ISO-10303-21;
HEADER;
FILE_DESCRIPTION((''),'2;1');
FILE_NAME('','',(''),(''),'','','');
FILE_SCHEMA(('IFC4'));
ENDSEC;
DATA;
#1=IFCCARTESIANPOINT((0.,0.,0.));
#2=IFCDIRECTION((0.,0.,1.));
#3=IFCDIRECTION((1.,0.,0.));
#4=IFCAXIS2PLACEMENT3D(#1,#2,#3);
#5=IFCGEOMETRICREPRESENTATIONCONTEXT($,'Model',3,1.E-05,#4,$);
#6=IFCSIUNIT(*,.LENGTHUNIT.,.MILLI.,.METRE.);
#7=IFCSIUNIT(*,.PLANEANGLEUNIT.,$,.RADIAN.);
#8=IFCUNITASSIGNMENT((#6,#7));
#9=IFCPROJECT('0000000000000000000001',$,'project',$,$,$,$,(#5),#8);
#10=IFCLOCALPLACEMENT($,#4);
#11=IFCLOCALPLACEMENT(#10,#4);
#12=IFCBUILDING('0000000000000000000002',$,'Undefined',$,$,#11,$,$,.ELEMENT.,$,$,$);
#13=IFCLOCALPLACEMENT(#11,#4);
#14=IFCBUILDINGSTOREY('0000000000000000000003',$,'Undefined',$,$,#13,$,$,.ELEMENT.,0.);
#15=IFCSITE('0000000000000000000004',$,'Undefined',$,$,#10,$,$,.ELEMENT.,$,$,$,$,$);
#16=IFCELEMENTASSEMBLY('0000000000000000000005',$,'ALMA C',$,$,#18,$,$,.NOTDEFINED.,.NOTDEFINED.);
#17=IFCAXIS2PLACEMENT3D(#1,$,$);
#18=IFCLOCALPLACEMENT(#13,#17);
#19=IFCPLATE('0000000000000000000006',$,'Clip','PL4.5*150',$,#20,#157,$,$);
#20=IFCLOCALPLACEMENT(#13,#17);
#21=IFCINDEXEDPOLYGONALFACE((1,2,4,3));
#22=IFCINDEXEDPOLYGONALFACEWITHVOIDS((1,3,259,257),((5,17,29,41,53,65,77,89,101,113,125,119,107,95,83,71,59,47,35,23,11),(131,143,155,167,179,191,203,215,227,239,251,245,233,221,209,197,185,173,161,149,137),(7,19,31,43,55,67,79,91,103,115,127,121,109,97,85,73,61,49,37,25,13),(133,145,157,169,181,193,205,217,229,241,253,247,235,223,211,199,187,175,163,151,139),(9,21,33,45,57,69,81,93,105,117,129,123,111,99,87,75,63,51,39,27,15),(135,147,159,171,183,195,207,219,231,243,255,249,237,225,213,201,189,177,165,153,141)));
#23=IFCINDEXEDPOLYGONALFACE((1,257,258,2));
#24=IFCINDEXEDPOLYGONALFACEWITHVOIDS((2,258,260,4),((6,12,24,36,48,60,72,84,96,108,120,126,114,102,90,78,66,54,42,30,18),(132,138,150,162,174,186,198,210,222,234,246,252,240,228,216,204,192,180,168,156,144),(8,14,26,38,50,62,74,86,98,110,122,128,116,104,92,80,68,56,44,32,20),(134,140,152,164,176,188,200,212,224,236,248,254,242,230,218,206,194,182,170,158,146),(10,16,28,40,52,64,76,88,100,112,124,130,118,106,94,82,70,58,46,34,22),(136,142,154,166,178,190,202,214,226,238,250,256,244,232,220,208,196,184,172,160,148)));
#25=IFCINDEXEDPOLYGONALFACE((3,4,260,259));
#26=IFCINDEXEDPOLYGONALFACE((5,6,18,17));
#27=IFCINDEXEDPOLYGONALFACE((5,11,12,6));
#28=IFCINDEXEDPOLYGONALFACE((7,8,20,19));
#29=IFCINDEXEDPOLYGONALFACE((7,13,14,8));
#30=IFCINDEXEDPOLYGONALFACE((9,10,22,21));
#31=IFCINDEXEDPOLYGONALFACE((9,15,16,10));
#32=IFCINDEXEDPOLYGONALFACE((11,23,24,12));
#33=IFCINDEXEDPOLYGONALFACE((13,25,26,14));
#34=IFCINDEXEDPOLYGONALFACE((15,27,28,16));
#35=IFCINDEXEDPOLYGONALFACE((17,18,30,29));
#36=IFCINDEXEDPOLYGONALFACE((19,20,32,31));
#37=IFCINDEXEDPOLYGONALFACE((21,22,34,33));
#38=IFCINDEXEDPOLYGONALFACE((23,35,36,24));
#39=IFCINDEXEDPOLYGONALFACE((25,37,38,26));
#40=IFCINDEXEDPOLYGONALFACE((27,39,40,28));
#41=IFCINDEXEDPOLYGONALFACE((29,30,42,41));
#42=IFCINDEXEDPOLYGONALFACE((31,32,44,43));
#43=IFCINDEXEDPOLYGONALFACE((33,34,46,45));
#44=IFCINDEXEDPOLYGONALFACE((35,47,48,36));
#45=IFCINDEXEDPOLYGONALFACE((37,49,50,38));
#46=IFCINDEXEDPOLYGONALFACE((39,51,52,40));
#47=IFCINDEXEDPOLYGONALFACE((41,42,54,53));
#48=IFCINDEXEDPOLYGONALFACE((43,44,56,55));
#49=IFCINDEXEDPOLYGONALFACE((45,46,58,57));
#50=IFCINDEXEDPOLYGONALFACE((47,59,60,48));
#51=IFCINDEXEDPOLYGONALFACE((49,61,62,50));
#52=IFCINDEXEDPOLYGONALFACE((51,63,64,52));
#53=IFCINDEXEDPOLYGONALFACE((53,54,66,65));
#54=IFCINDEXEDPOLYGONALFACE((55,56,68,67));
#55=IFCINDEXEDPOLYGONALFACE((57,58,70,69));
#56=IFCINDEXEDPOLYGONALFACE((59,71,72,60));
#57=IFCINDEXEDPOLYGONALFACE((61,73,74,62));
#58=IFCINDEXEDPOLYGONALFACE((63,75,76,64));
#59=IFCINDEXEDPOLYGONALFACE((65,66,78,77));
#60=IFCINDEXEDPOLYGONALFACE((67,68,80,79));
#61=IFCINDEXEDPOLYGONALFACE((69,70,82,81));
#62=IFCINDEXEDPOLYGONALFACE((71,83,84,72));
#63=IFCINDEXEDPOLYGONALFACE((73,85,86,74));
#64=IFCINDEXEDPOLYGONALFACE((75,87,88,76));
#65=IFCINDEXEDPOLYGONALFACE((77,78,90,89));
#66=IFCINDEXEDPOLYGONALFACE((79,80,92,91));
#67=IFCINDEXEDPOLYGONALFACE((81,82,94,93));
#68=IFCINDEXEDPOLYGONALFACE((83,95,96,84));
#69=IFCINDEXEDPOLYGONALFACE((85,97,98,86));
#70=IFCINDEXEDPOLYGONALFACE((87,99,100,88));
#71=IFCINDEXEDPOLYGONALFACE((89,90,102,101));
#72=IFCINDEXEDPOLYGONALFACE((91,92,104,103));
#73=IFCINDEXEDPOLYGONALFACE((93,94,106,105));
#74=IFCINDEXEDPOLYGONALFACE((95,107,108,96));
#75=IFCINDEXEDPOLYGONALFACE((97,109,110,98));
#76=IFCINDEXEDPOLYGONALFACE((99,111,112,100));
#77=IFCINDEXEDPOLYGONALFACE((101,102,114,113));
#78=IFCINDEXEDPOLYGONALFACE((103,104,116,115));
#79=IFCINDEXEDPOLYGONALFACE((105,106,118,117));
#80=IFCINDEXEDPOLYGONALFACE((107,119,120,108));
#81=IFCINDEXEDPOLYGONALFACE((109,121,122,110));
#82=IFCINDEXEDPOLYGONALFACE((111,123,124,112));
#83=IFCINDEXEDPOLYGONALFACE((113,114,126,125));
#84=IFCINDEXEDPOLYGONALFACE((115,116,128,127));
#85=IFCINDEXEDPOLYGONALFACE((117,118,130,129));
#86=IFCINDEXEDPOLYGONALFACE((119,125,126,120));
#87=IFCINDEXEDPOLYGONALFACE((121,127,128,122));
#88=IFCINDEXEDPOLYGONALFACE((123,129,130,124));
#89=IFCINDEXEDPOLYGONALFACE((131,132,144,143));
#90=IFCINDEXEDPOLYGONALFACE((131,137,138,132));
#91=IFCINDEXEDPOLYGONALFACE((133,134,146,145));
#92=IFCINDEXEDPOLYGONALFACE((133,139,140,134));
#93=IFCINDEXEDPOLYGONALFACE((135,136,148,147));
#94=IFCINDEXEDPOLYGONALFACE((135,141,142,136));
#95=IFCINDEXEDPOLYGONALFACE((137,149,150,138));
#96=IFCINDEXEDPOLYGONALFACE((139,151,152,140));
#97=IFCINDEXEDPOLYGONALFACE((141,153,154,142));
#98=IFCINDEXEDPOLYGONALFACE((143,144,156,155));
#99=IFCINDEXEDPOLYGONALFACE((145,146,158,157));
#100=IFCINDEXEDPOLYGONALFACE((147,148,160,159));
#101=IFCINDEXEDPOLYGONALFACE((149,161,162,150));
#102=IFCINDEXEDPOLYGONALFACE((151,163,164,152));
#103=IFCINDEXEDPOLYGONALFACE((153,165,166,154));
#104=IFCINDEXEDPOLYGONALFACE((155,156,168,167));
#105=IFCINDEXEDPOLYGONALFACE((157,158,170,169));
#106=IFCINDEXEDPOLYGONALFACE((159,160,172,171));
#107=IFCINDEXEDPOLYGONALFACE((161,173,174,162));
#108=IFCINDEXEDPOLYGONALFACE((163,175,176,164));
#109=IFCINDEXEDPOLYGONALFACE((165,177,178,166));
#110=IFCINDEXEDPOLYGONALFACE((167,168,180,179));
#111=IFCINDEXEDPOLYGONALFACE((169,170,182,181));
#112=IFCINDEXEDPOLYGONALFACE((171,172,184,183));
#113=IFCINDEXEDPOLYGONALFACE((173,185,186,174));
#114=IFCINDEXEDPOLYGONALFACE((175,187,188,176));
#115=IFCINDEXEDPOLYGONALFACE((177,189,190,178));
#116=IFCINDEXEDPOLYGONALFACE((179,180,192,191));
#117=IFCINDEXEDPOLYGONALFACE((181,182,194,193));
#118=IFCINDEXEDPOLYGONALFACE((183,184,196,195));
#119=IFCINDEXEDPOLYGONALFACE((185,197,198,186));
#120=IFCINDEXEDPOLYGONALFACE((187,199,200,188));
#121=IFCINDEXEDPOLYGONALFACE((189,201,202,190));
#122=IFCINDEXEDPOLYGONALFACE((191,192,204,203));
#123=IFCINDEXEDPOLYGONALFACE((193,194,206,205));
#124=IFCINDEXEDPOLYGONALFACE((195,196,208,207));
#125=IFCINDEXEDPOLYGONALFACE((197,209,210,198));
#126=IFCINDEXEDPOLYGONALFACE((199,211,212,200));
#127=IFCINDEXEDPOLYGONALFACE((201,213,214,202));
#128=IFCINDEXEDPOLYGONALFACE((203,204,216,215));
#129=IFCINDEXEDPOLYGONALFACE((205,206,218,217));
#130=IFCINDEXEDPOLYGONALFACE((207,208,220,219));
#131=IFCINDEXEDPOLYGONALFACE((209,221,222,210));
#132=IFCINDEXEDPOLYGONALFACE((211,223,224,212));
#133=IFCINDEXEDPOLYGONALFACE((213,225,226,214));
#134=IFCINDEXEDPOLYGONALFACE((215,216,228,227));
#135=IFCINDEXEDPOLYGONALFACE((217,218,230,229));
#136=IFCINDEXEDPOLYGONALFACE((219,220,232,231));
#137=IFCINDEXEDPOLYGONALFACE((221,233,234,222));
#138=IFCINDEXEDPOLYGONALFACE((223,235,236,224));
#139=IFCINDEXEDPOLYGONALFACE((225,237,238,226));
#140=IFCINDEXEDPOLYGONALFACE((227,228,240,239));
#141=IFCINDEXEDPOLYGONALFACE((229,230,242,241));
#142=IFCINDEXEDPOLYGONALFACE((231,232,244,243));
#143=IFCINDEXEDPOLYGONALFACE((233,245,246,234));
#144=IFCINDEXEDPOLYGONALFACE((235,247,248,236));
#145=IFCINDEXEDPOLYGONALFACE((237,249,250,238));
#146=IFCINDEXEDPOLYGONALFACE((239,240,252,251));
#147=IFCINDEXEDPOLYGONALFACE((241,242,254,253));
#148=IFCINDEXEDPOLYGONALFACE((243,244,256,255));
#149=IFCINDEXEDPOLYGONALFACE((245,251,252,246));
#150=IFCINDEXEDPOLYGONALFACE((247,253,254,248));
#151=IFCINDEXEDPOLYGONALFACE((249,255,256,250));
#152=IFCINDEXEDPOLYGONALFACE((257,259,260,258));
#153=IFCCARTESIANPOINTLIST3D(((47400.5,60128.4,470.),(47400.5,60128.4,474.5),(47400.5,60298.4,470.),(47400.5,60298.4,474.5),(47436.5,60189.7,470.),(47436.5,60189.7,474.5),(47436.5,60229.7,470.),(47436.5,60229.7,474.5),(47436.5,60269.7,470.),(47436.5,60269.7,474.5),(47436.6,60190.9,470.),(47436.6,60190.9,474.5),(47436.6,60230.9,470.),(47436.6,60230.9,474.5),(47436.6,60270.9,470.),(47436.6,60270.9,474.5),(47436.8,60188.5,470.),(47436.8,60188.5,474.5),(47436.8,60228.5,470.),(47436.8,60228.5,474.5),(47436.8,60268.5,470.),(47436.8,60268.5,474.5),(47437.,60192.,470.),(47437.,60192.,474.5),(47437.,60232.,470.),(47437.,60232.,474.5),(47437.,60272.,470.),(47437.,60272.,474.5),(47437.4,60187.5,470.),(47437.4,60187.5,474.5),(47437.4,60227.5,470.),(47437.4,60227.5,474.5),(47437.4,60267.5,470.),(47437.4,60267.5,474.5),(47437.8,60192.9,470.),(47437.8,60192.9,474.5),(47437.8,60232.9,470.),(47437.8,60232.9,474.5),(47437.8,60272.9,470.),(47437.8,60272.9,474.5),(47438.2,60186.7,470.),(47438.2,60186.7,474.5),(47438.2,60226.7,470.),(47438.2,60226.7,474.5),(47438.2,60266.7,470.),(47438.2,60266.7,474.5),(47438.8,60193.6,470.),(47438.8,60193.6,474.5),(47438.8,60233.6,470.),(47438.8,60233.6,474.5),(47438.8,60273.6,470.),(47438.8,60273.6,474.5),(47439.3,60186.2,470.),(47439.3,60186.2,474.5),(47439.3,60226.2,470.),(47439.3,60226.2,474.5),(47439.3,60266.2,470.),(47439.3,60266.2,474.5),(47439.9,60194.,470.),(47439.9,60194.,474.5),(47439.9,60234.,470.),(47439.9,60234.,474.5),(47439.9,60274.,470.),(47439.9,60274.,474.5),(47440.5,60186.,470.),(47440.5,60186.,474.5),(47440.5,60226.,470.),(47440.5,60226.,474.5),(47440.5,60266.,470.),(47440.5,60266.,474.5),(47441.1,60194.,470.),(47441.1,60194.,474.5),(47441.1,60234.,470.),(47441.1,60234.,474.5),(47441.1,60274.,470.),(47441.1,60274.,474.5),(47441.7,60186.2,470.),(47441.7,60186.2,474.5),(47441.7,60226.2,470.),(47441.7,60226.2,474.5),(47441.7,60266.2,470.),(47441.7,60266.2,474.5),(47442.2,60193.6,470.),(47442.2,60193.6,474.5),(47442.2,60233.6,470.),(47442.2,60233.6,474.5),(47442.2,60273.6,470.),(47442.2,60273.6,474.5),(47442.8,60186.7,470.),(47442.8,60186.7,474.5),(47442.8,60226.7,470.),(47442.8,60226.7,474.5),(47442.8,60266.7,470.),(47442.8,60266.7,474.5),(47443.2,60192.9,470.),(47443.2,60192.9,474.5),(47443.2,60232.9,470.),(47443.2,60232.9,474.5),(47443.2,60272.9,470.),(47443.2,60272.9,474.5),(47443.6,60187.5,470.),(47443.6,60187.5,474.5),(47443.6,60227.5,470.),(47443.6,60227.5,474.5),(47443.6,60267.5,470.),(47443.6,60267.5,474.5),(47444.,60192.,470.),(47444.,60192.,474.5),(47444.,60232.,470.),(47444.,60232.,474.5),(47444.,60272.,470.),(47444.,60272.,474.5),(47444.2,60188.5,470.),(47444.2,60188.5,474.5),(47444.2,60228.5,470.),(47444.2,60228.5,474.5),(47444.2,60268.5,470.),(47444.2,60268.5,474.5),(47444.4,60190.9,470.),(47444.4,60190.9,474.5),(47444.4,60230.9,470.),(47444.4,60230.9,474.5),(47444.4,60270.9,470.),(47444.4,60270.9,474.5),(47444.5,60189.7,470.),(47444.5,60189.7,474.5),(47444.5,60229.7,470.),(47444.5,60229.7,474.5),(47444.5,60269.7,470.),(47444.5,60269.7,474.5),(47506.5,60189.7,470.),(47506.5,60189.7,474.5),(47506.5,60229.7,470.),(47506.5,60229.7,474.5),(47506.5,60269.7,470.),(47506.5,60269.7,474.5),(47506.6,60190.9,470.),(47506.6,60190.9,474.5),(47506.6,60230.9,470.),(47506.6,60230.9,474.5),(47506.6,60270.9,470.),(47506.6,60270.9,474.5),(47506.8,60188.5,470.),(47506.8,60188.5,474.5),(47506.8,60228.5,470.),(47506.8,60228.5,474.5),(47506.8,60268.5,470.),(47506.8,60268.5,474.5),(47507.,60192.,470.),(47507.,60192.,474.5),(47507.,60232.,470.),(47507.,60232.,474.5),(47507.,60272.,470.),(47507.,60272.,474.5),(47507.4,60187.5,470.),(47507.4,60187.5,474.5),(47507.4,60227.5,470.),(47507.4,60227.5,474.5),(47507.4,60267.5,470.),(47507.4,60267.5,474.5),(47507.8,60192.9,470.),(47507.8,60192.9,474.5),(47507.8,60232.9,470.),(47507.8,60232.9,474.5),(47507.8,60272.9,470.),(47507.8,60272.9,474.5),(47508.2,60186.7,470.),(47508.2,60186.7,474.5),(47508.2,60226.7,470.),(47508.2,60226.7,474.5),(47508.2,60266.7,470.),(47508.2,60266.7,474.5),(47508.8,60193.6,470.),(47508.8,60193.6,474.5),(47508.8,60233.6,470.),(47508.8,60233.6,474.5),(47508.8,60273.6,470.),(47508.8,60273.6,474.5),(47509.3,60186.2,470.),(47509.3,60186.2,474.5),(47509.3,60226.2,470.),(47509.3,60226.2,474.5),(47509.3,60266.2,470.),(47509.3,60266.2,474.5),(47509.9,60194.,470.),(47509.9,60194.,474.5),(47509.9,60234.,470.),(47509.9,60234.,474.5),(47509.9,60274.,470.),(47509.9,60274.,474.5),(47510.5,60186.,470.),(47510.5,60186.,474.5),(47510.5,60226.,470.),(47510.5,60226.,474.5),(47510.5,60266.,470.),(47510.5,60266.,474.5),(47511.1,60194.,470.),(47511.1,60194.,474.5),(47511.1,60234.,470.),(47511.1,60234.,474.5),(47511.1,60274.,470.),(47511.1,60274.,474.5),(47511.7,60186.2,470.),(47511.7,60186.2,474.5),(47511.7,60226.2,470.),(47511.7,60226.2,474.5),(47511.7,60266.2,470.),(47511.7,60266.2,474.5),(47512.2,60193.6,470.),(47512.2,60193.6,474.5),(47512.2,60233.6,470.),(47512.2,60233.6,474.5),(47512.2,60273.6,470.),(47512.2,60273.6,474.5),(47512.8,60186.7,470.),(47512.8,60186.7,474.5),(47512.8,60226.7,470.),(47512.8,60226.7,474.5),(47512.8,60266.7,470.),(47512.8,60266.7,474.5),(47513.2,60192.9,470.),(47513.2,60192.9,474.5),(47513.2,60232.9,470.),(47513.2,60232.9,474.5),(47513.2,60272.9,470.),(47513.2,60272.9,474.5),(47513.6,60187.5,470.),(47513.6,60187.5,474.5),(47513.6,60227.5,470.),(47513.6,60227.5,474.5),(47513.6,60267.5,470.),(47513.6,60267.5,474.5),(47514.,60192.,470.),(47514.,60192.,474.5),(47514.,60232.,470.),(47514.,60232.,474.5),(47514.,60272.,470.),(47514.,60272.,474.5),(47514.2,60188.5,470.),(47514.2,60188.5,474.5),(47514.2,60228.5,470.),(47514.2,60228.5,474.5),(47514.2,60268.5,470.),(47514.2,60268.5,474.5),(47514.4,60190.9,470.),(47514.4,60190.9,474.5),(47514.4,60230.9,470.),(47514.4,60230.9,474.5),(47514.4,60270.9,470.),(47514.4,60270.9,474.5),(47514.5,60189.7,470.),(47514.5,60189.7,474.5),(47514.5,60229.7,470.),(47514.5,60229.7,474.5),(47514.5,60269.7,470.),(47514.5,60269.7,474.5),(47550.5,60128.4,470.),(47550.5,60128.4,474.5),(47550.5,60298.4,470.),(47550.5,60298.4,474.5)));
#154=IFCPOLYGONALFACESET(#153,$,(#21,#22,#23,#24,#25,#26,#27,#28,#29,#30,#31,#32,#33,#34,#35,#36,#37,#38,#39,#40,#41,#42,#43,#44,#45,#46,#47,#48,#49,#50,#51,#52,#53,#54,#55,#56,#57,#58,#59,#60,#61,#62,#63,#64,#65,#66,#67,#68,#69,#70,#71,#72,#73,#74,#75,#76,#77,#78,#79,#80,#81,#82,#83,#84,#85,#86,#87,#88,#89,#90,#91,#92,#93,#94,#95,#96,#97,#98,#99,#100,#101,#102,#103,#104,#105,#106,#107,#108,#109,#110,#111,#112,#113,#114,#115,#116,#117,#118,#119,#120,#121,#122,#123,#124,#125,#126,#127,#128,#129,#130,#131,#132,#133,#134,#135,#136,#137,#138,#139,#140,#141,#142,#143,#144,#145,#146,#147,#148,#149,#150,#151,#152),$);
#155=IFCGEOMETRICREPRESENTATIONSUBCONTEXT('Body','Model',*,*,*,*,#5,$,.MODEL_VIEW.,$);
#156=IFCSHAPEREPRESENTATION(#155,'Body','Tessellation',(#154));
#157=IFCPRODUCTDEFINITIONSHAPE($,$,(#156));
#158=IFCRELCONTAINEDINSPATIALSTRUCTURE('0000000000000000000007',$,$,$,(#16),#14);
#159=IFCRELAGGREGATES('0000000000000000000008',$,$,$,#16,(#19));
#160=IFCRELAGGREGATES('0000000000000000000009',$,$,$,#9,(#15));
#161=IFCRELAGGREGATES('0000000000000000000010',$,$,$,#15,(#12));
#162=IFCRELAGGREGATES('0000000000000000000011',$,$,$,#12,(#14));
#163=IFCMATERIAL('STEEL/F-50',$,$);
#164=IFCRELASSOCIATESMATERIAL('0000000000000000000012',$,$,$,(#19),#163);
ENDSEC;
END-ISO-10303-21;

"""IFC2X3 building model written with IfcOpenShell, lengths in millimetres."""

from ifc_helpers import new_model, si_unit, frame, origin_with_axes, origin_2d_with_axis, place, context, subcontext, project, spatial, polyline, circle, outline, extrude, source, transform, mapped, material, element, aggregate, save


model = new_model("IFC2X3")

# Units and contexts
model_context = context("Model", 3, precision=1e-05, world=origin_with_axes())
body_context = subcontext(model_context, "Body", "Model", "MODEL_VIEW")
ifc_project = project(units=[si_unit("LENGTHUNIT", "METRE", prefix="MILLI"), si_unit("PLANEANGLEUNIT", "RADIAN")], contexts=[model_context])

# Site, building, storey
site_placement = place(None, origin_with_axes())
site = spatial("IfcSite", under=ifc_project, at=site_placement, Name="Undefined", CompositionType="ELEMENT")
building_placement = place(site_placement, origin_with_axes())
building = spatial("IfcBuilding", under=site, at=building_placement, Name="Undefined", CompositionType="ELEMENT")
storey_placement = place(building_placement, origin_with_axes())
storey = spatial("IfcBuildingStorey", under=building, at=storey_placement, Name="Undefined", CompositionType="ELEMENT", Elevation=0.0)

# Element assembly
assembly_1_placement = place(storey_placement, origin_with_axes())
assembly_1 = element("IfcElementAssembly", 1, at=assembly_1_placement, inside=storey, Name="ALMA C", AssemblyPlace="NOTDEFINED", PredefinedType="NOTDEFINED")

# Shared definitions
ifc_material_1 = material(Name="STEEL/F-50")

# Plate, openings
shared_shape_1 = source(origin_with_axes(), body_context, "Body", "SweptSolid", [
    extrude(circle(Radius=4.0, at=origin_2d_with_axis()), frame((0.0, -4.6, 0.0), z_axis=(0.0, 1.0, 0.0), x_axis=(1.0, 0.0, 0.0)), (0.0, 0.0, 1.0), 4.7),
])
plate_1_placement = place(assembly_1_placement, frame((47400.5, 60128.4, 472.2), z_axis=(0.0, 0.0, -1.0), x_axis=(0.0, 1.0, 0.0)))
plate_1 = element("IfcPlate", 2, at=plate_1_placement, material=ifc_material_1, Name="Clip", Description="PL4.5*150", context=body_context, shape_type="SweptSolid", body=[
    extrude(outline(polyline([(0.0, 0.0), (170.0, 0.0), (170.0, 150.0), (0.0, 150.0), (0.0, 0.0)])), frame((0.0, 0.0, -2.2), z_axis=(0.0, 0.0, 1.0), x_axis=(1.0, 0.0, 0.0)), (0.0, 0.0, 1.0), 4.5),
])
opening_1_placement = place(assembly_1_placement, frame((47510.5, 60270.0, 470.0), z_axis=(1.0, 0.0, 0.0), x_axis=(0.0, -1.0, 0.0)))
element("IfcOpeningElement", 3, at=opening_1_placement, cuts=plate_1, ObjectType="Opening", context=body_context, shape_type="MappedRepresentation", body=[
    mapped(shared_shape_1, transform((0.0, 0.0, 0.0))),
    mapped(shared_shape_1, transform((40.0, 0.0, 0.0))),
    mapped(shared_shape_1, transform((80.0, 0.0, 0.0))),
])
opening_2_placement = place(assembly_1_placement, frame((47440.5, 60270.0, 470.0), z_axis=(1.0, 0.0, 0.0), x_axis=(0.0, -1.0, 0.0)))
element("IfcOpeningElement", 4, at=opening_2_placement, cuts=plate_1, ObjectType="Opening", context=body_context, shape_type="MappedRepresentation", body=[
    mapped(shared_shape_1, transform((0.0, 0.0, 0.0))),
    mapped(shared_shape_1, transform((40.0, 0.0, 0.0))),
    mapped(shared_shape_1, transform((80.0, 0.0, 0.0))),
])
aggregate(assembly_1, [plate_1])

save(model, "model.ifc")
